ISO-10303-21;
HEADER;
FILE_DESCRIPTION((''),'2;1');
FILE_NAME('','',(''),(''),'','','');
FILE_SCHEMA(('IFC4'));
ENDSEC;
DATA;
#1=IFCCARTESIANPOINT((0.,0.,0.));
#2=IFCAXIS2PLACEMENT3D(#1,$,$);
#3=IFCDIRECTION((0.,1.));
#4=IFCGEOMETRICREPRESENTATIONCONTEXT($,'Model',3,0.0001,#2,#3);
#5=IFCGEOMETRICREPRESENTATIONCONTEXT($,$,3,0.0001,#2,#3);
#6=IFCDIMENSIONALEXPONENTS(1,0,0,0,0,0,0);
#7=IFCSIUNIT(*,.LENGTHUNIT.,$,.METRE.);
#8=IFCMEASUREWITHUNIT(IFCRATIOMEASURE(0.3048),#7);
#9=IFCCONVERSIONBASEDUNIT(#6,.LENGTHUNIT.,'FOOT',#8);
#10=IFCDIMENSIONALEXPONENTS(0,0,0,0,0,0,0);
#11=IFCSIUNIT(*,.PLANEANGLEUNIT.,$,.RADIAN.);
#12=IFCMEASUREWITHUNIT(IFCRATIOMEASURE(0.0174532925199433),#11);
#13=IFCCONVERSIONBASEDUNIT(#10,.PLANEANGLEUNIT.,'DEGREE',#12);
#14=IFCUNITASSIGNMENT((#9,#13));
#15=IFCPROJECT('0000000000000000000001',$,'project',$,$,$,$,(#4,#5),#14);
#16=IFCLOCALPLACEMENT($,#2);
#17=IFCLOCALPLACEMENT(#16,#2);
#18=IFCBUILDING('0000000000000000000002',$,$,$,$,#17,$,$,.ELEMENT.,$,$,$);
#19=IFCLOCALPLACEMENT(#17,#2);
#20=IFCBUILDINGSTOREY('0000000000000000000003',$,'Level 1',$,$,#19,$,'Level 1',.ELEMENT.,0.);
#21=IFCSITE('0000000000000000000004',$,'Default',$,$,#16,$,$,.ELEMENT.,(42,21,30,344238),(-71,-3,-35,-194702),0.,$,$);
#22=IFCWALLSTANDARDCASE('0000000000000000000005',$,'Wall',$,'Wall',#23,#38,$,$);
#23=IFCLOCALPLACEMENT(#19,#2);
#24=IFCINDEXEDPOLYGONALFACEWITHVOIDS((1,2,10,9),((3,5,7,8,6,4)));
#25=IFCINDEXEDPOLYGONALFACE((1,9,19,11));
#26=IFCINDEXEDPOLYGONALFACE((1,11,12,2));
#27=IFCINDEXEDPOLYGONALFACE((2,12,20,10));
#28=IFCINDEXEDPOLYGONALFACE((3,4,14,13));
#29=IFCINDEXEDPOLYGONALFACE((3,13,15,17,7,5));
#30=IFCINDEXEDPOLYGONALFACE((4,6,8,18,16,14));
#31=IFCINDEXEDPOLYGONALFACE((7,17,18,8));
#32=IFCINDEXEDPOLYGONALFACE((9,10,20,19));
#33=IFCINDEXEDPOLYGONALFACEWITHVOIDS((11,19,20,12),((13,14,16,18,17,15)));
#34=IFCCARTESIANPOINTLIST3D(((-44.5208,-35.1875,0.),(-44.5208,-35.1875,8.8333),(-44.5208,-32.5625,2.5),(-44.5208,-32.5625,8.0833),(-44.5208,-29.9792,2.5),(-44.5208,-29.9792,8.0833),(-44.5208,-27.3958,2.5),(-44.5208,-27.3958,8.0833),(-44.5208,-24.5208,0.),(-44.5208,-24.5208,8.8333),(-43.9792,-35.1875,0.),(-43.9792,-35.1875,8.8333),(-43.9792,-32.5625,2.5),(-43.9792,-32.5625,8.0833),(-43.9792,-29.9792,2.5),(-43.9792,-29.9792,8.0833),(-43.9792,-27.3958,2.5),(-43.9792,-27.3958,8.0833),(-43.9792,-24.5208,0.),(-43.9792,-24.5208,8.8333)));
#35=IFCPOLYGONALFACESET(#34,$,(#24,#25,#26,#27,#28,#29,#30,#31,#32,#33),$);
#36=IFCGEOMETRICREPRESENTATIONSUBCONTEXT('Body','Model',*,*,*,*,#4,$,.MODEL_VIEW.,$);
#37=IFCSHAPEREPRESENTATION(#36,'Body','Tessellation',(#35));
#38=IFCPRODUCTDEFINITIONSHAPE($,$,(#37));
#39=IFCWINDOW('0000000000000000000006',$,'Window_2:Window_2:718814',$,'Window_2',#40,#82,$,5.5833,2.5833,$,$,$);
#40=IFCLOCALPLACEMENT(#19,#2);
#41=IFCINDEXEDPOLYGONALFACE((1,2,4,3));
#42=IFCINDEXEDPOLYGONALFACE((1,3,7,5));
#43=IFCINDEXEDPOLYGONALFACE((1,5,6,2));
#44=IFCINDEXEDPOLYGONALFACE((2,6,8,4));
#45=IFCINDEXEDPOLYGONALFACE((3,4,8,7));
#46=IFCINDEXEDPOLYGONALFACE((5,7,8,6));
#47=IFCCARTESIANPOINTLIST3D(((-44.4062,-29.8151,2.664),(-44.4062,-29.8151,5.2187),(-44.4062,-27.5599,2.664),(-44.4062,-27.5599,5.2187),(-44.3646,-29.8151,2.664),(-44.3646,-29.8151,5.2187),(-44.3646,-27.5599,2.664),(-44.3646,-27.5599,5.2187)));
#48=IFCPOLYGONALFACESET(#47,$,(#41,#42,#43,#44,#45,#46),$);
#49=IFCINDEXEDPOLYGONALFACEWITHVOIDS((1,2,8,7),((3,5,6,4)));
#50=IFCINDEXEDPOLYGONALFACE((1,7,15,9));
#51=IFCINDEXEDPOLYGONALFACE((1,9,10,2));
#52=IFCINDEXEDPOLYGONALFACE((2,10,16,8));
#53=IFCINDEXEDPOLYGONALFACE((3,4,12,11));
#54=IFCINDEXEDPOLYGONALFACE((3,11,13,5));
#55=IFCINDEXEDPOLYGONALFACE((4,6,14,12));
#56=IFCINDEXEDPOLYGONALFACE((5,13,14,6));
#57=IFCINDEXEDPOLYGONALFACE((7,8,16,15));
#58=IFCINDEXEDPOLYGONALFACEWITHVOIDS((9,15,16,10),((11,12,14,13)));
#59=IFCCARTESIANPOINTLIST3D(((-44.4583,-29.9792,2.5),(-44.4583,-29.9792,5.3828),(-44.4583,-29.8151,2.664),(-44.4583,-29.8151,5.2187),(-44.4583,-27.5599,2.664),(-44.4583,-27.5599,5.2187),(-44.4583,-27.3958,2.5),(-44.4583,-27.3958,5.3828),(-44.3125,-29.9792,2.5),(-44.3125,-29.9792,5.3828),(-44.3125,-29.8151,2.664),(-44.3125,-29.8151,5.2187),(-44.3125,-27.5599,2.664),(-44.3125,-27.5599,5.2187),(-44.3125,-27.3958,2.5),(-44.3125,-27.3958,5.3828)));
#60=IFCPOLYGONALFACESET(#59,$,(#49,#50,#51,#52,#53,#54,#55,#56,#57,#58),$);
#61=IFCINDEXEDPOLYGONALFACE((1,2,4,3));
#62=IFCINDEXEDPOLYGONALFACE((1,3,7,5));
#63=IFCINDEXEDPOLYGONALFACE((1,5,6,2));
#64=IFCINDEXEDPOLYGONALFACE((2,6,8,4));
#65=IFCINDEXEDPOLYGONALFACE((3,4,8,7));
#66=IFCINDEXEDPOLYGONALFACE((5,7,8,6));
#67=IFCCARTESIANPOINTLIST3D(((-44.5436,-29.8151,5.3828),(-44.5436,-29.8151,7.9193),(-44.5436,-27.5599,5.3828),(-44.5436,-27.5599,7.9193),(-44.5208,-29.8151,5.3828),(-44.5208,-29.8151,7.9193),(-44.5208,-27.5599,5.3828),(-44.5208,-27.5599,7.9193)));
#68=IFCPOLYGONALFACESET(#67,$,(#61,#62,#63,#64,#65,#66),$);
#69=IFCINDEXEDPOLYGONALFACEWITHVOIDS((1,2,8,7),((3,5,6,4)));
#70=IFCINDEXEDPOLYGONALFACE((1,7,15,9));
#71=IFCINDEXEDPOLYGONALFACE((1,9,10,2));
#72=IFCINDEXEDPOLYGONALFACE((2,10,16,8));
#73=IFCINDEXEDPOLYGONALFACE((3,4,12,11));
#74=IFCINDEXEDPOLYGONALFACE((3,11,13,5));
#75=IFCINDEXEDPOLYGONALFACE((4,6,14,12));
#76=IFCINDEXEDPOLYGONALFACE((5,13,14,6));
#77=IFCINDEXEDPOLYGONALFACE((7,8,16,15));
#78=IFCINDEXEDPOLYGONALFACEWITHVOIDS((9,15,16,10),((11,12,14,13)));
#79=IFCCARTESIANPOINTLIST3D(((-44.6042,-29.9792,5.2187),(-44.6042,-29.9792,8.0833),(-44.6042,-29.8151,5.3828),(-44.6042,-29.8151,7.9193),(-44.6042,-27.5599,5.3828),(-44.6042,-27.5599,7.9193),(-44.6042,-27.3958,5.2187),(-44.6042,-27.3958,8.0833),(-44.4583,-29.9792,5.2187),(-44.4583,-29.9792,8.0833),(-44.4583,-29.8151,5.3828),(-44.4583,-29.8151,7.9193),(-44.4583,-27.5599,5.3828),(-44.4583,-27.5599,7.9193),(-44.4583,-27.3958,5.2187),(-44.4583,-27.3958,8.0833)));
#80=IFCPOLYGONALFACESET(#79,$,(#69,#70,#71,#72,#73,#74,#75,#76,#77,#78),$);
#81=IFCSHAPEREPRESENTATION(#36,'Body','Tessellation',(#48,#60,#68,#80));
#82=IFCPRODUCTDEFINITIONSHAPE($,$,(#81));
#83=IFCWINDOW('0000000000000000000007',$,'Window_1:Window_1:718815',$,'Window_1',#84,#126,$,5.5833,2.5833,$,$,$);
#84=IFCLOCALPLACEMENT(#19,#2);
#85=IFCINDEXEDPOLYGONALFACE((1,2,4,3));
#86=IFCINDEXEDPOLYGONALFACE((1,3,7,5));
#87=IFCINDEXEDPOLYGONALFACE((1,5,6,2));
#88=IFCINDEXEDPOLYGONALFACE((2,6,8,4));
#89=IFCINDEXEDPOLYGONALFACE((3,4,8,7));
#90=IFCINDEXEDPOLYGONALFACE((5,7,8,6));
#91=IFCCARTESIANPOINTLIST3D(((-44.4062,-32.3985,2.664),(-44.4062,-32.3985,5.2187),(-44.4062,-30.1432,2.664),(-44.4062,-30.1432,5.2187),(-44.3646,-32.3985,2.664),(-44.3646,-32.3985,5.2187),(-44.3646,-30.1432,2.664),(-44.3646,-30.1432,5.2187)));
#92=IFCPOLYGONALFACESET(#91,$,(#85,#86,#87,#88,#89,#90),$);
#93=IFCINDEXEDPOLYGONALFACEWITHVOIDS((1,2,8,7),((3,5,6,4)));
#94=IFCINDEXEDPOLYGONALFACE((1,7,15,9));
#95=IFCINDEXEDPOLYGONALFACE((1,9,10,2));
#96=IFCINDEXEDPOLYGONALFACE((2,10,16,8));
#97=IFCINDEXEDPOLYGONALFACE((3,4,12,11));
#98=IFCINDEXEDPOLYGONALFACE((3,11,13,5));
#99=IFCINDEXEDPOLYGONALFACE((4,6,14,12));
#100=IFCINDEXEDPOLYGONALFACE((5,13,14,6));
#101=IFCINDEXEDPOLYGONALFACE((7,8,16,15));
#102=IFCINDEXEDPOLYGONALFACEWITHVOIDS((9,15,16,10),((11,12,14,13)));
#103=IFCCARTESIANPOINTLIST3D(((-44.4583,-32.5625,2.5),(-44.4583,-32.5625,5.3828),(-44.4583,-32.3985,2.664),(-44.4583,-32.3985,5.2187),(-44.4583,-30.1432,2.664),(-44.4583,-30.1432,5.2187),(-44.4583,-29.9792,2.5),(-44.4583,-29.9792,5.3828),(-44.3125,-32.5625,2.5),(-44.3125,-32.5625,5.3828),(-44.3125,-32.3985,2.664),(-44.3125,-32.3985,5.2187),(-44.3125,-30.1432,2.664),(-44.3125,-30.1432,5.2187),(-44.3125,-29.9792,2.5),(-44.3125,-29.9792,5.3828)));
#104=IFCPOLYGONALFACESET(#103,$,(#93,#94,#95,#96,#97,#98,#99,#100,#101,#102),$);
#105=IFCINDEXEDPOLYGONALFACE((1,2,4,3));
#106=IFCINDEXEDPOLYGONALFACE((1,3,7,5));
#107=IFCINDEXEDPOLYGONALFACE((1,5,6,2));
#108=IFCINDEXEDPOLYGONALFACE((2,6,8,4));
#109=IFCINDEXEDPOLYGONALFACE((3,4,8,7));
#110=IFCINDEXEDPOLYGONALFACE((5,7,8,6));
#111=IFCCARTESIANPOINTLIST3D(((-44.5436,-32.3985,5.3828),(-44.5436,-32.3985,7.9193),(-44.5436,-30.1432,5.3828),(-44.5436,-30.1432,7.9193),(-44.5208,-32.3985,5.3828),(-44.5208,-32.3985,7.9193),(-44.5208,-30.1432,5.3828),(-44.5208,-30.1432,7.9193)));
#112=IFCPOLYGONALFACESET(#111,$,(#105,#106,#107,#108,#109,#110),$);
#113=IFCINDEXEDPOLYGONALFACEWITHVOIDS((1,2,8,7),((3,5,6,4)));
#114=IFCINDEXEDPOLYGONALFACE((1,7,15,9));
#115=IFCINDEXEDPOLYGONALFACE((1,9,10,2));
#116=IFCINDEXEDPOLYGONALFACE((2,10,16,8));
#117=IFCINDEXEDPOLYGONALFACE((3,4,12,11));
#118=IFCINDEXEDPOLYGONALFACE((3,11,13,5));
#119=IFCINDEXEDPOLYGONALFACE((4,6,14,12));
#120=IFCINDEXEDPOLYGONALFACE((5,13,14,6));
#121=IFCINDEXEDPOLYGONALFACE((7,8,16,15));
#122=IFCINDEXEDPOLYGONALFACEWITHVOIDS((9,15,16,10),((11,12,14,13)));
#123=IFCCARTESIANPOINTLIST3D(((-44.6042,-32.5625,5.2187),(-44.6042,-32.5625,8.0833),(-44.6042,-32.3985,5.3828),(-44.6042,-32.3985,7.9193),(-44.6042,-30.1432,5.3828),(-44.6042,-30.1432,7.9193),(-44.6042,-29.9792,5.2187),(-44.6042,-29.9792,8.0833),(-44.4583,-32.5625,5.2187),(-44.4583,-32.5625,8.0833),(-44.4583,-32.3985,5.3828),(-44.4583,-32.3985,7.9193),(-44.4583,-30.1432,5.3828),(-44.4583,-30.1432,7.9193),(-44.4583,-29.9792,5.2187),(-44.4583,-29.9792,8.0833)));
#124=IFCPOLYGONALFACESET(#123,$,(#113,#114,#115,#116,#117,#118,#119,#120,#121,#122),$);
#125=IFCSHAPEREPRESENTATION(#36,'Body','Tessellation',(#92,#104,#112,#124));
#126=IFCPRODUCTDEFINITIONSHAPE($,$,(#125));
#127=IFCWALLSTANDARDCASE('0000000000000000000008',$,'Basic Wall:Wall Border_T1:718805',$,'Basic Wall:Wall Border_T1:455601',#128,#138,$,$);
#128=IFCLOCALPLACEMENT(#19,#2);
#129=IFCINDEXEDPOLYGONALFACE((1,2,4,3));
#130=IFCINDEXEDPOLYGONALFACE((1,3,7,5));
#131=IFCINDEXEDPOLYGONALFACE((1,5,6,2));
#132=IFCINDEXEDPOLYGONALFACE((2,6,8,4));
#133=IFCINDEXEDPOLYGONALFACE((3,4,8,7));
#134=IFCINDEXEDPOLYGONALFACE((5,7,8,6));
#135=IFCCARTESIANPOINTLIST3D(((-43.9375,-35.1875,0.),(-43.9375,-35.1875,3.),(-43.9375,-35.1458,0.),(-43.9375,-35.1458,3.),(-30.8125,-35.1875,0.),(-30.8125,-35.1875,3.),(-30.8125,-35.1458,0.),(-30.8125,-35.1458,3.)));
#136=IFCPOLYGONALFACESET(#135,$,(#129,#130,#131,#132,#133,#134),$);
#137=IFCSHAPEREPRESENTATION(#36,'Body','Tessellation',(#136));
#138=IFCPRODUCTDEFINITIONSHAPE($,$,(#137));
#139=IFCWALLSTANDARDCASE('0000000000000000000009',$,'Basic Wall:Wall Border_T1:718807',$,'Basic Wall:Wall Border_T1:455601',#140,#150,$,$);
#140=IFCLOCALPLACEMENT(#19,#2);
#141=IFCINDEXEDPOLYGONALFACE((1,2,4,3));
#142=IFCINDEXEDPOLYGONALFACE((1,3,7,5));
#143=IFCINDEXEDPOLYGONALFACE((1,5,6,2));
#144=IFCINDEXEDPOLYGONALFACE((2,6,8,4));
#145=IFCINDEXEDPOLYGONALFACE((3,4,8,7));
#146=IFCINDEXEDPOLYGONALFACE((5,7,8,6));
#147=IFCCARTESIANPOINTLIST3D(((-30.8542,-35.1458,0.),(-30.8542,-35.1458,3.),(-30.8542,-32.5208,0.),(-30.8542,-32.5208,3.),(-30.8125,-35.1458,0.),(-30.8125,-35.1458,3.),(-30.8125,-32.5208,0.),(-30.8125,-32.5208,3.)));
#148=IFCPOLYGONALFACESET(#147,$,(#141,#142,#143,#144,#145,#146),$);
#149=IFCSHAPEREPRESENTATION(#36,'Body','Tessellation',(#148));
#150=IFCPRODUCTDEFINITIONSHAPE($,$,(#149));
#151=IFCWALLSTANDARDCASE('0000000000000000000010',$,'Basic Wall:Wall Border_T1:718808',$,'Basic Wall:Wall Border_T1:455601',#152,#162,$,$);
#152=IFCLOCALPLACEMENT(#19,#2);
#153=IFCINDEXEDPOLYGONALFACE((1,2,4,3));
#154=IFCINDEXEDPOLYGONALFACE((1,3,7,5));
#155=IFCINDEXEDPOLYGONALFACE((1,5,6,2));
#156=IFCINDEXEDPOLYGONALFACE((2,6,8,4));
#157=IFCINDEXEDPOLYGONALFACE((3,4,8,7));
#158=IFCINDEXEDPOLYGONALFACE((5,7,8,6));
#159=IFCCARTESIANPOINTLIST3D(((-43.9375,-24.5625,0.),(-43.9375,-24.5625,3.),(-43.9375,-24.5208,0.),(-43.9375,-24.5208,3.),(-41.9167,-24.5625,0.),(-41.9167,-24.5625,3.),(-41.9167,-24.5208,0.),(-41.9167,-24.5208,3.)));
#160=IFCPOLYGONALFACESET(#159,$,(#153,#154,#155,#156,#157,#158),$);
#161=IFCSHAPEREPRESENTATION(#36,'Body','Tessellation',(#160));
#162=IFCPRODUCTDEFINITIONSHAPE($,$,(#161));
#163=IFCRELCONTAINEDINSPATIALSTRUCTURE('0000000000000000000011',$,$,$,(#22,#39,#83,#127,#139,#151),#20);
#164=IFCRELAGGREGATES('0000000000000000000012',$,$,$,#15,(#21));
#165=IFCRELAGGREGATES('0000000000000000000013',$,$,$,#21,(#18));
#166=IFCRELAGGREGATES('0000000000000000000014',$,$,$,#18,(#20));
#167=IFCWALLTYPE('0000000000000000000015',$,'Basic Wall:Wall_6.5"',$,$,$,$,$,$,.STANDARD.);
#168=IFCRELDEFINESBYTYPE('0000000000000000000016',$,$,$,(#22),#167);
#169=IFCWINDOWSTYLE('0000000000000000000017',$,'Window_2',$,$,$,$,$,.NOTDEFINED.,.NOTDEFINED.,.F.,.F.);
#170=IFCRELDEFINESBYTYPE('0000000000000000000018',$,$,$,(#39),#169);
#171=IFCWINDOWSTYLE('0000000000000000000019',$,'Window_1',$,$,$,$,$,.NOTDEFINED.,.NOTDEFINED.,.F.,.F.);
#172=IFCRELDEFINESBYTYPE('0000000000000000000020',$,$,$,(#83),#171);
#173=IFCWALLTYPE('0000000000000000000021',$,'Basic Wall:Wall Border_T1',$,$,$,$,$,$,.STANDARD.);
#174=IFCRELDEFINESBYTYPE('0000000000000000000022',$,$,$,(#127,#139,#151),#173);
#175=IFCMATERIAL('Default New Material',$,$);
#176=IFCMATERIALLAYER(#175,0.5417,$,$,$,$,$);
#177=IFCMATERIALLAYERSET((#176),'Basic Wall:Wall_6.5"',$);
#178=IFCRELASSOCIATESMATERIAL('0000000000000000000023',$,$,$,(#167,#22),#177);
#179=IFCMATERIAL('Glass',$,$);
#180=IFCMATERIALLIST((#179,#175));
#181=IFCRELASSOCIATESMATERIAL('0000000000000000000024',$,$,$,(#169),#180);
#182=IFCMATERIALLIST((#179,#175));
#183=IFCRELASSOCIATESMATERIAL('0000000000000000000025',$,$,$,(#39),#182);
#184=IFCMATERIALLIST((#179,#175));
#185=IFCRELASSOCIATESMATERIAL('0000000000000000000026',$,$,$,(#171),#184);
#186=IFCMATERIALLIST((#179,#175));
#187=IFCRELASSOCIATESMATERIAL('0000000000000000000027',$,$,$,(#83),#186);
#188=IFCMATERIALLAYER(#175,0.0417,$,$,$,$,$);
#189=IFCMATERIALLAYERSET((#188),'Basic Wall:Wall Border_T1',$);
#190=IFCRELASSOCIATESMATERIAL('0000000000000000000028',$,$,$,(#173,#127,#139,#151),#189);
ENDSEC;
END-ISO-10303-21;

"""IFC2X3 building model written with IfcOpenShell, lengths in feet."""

from ifc_helpers import new_model, entity, si_unit, converted_unit, direction, frame, frame_2d, origin, origin_2d_with_axis, place, context, subcontext, project, spatial, polyline, rectangle, outline, extrude, source, transform, mapped, material, material_list, layer, layer_set, layer_usage, type_object, type_shapes, element, fill, save


model = new_model("IFC2X3")

# Units and contexts
model_context = context("Model", 3, precision=0.0001, world=origin(), true_north=direction((0.0, 1.0)))
context_of_model = context(None, 3, precision=0.0001, world=origin(), true_north=direction((0.0, 1.0)))
body_context = subcontext(model_context, "Body", "Model", "MODEL_VIEW")
ifc_project = project(units=[converted_unit("LENGTHUNIT", "FOOT", entity("IfcRatioMeasure", 0.3048), si_unit("LENGTHUNIT", "METRE"), dimensions=[1, 0, 0, 0, 0, 0, 0]), converted_unit("PLANEANGLEUNIT", "DEGREE", entity("IfcRatioMeasure", 0.0174532925199433), si_unit("PLANEANGLEUNIT", "RADIAN"), dimensions=[0, 0, 0, 0, 0, 0, 0])], contexts=[model_context, context_of_model])

# Site, building, storey
site_placement = place(None, origin())
site = spatial("IfcSite", under=ifc_project, at=site_placement, Name="Default", CompositionType="ELEMENT", RefLatitude=(42, 21, 30, 344238), RefLongitude=(-71, -3, -35, -194702), RefElevation=0.0)
building_placement = place(site_placement, origin())
building = spatial("IfcBuilding", under=site, at=building_placement, CompositionType="ELEMENT")
storey_placement = place(building_placement, origin())
storey = spatial("IfcBuildingStorey", under=building, at=storey_placement, Name="Level 1", LongName="Level 1", CompositionType="ELEMENT", Elevation=0.0)

# Wall, openings, windows
ifc_material_1 = material(Name="Default New Material")
ifc_layer_1 = layer(ifc_material_1, 0.5417)
ifc_layer_set_1 = layer_set([ifc_layer_1], Name="Basic Wall:Wall_6.5\"")
ifc_layer_usage_1 = layer_usage(ifc_layer_set_1, "AXIS2", "NEGATIVE", 0.2708)
wall_type_1 = type_object("IfcWallType", Name="Basic Wall:Wall_6.5\"", PredefinedType="STANDARD", material=ifc_layer_set_1)
wall_1_placement = place(storey_placement, frame((-44.25, -35.1875, 0.0), z_axis=(0.0, 0.0, 1.0), x_axis=(0.0, 1.0, 0.0)))
wall_1 = element("IfcWallStandardCase", 1, at=wall_1_placement, inside=storey, type_object=wall_type_1, material=ifc_layer_usage_1, Name="Wall", ObjectType="Wall", context=body_context, shape_type="SweptSolid", body=[
    extrude(rectangle(XDim=10.6667, YDim=0.5417, at=frame_2d((5.3333, 0.0), x_axis=(-1.0, 0.0))), origin(), (0.0, 0.0, 1.0), 8.8333),
])
opening_1_placement = place(wall_1_placement, frame((5.2083, -0.2708, 2.5)))
opening_1 = element("IfcOpeningElement", 2, at=opening_1_placement, cuts=wall_1, ObjectType="Opening", context=body_context, shape_type="SweptSolid", body=[
    extrude(rectangle(XDim=5.5833, YDim=2.5833, at=frame_2d((2.7917, 1.2917), x_axis=(-1.0, 0.0))), frame((0.0, 0.0, 0.0), z_axis=(0.0, 1.0, 0.0), x_axis=(0.0, 0.0, 1.0)), (0.0, 0.0, 1.0), 0.5417),
])
opening_2_placement = place(wall_1_placement, frame((2.625, -0.2708, 2.5)))
opening_2 = element("IfcOpeningElement", 3, at=opening_2_placement, cuts=wall_1, ObjectType="Opening", context=body_context, shape_type="SweptSolid", body=[
    extrude(rectangle(XDim=5.5833, YDim=2.5833, at=frame_2d((2.7917, 1.2917), x_axis=(-1.0, 0.0))), frame((0.0, 0.0, 0.0), z_axis=(0.0, 1.0, 0.0), x_axis=(0.0, 0.0, 1.0)), (0.0, 0.0, 1.0), 0.5417),
])
ifc_material_2 = material(Name="Glass")
ifc_material_list_1 = material_list([ifc_material_2, ifc_material_1])
ifc_material_list_2 = material_list([ifc_material_2, ifc_material_1])
window_style_1 = type_object("IfcWindowStyle", Name="Window_2", ConstructionType="NOTDEFINED", OperationType="NOTDEFINED", ParameterTakesPrecedence=False, Sizeable=False, material=ifc_material_list_2)
shared_shape_1 = source(origin(), body_context, "Body", "SweptSolid", [
    extrude(rectangle(XDim=0.0417, YDim=2.2552, at=origin_2d_with_axis()), frame((1.2917, 0.4062, 0.164), z_axis=(0.0, 0.0, 1.0), x_axis=(0.0, -1.0, 0.0)), (0.0, 0.0, 1.0), 2.5547),
    extrude(outline(polyline([(-1.2917, -1.4414), (1.2917, -1.4414), (1.2917, 1.4414), (-1.2917, 1.4414), (-1.2917, -1.4414)]), holes=[polyline([(-1.1276, -1.2774), (-1.1276, 1.2774), (1.1276, 1.2774), (1.1276, -1.2774), (-1.1276, -1.2774)])]), frame((1.2917, 0.3333, 1.4414), z_axis=(0.0, 1.0, 0.0), x_axis=(1.0, 0.0, 0.0)), (0.0, 0.0, 1.0), 0.1458),
    extrude(rectangle(XDim=0.0228, YDim=2.2552, at=origin_2d_with_axis()), frame((1.2917, 0.553, 2.8828), z_axis=(0.0, 0.0, 1.0), x_axis=(0.0, 1.0, 0.0)), (0.0, 0.0, 1.0), 2.5365),
    extrude(outline(polyline([(-1.2917, -1.4323), (1.2917, -1.4323), (1.2917, 1.4323), (-1.2917, 1.4323), (-1.2917, -1.4323)]), holes=[polyline([(-1.1276, -1.2682), (-1.1276, 1.2682), (1.1276, 1.2682), (1.1276, -1.2682), (-1.1276, -1.2682)])]), frame((1.2917, 0.4792, 4.151), z_axis=(0.0, 1.0, 0.0), x_axis=(1.0, 0.0, 0.0)), (0.0, 0.0, 1.0), 0.1458),
])
type_shapes(window_style_1, [shared_shape_1])
window_1_placement = place(opening_1_placement, origin())
window_1 = element("IfcWindow", 4, at=window_1_placement, inside=storey, type_object=window_style_1, material=ifc_material_list_1, Name="Window_2:Window_2:718814", ObjectType="Window_2", OverallHeight=5.5833, OverallWidth=2.5833, context=body_context, shape_type="MappedRepresentation", body=[
    mapped(shared_shape_1, transform((0.0, 0.0, 0.0), scale=1.0)),
])
fill(opening_1, window_1)
ifc_material_list_3 = material_list([ifc_material_2, ifc_material_1])
ifc_material_list_4 = material_list([ifc_material_2, ifc_material_1])
window_style_2 = type_object("IfcWindowStyle", Name="Window_1", ConstructionType="NOTDEFINED", OperationType="NOTDEFINED", ParameterTakesPrecedence=False, Sizeable=False, material=ifc_material_list_4)
shared_shape_2 = source(origin(), body_context, "Body", "SweptSolid", [
    extrude(rectangle(XDim=0.0417, YDim=2.2552, at=origin_2d_with_axis()), frame((1.2917, 0.4062, 0.164), z_axis=(0.0, 0.0, 1.0), x_axis=(0.0, -1.0, 0.0)), (0.0, 0.0, 1.0), 2.5547),
    extrude(outline(polyline([(-1.2917, -1.4414), (1.2917, -1.4414), (1.2917, 1.4414), (-1.2917, 1.4414), (-1.2917, -1.4414)]), holes=[polyline([(-1.1276, -1.2774), (-1.1276, 1.2774), (1.1276, 1.2774), (1.1276, -1.2774), (-1.1276, -1.2774)])]), frame((1.2917, 0.3333, 1.4414), z_axis=(0.0, 1.0, 0.0), x_axis=(1.0, 0.0, 0.0)), (0.0, 0.0, 1.0), 0.1458),
    extrude(rectangle(XDim=0.0228, YDim=2.2552, at=origin_2d_with_axis()), frame((1.2917, 0.553, 2.8828), z_axis=(0.0, 0.0, 1.0), x_axis=(0.0, 1.0, 0.0)), (0.0, 0.0, 1.0), 2.5365),
    extrude(outline(polyline([(-1.2917, -1.4323), (1.2917, -1.4323), (1.2917, 1.4323), (-1.2917, 1.4323), (-1.2917, -1.4323)]), holes=[polyline([(-1.1276, -1.2682), (-1.1276, 1.2682), (1.1276, 1.2682), (1.1276, -1.2682), (-1.1276, -1.2682)])]), frame((1.2917, 0.4792, 4.151), z_axis=(0.0, 1.0, 0.0), x_axis=(1.0, 0.0, 0.0)), (0.0, 0.0, 1.0), 0.1458),
])
type_shapes(window_style_2, [shared_shape_2])
window_2_placement = place(opening_2_placement, origin())
window_2 = element("IfcWindow", 5, at=window_2_placement, inside=storey, type_object=window_style_2, material=ifc_material_list_3, Name="Window_1:Window_1:718815", ObjectType="Window_1", OverallHeight=5.5833, OverallWidth=2.5833, context=body_context, shape_type="MappedRepresentation", body=[
    mapped(shared_shape_2, transform((0.0, 0.0, 0.0), scale=1.0)),
])
fill(opening_2, window_2)

# Walls
ifc_layer_2 = layer(ifc_material_1, 0.0417)
ifc_layer_set_2 = layer_set([ifc_layer_2], Name="Basic Wall:Wall Border_T1")
ifc_layer_usage_2 = layer_usage(ifc_layer_set_2, "AXIS2", "NEGATIVE", 0.0208)
wall_type_2 = type_object("IfcWallType", Name="Basic Wall:Wall Border_T1", PredefinedType="STANDARD", material=ifc_layer_set_2)
wall_2_placement = place(storey_placement, frame((-43.9375, -35.1667, 0.0)))
element("IfcWallStandardCase", 6, at=wall_2_placement, inside=storey, type_object=wall_type_2, material=ifc_layer_usage_2, Name="Basic Wall:Wall Border_T1:718805", ObjectType="Basic Wall:Wall Border_T1:455601", context=body_context, shape_type="SweptSolid", body=[
    extrude(rectangle(XDim=13.125, YDim=0.0417, at=frame_2d((6.5625, 0.0), x_axis=(-1.0, 0.0))), origin(), (0.0, 0.0, 1.0), 3.0),
])
ifc_layer_usage_3 = layer_usage(ifc_layer_set_2, "AXIS2", "NEGATIVE", 0.0208)
wall_3_placement = place(storey_placement, frame((-30.8333, -35.1458, 0.0), z_axis=(0.0, 0.0, 1.0), x_axis=(0.0, 1.0, 0.0)))
element("IfcWallStandardCase", 7, at=wall_3_placement, inside=storey, type_object=wall_type_2, material=ifc_layer_usage_3, Name="Basic Wall:Wall Border_T1:718807", ObjectType="Basic Wall:Wall Border_T1:455601", context=body_context, shape_type="SweptSolid", body=[
    extrude(rectangle(XDim=2.625, YDim=0.0417, at=frame_2d((1.3125, 0.0), x_axis=(-1.0, 0.0))), origin(), (0.0, 0.0, 1.0), 3.0),
])
ifc_layer_usage_4 = layer_usage(ifc_layer_set_2, "AXIS2", "POSITIVE", -0.0208)
wall_4_placement = place(storey_placement, frame((-43.9375, -24.5417, 0.0)))
element("IfcWallStandardCase", 8, at=wall_4_placement, inside=storey, type_object=wall_type_2, material=ifc_layer_usage_4, Name="Basic Wall:Wall Border_T1:718808", ObjectType="Basic Wall:Wall Border_T1:455601", context=body_context, shape_type="SweptSolid", body=[
    extrude(rectangle(XDim=2.0208, YDim=0.0417, at=frame_2d((1.0104, 0.0), x_axis=(-1.0, 0.0))), origin(), (0.0, 0.0, 1.0), 3.0),
])

save(model, "model.ifc")
